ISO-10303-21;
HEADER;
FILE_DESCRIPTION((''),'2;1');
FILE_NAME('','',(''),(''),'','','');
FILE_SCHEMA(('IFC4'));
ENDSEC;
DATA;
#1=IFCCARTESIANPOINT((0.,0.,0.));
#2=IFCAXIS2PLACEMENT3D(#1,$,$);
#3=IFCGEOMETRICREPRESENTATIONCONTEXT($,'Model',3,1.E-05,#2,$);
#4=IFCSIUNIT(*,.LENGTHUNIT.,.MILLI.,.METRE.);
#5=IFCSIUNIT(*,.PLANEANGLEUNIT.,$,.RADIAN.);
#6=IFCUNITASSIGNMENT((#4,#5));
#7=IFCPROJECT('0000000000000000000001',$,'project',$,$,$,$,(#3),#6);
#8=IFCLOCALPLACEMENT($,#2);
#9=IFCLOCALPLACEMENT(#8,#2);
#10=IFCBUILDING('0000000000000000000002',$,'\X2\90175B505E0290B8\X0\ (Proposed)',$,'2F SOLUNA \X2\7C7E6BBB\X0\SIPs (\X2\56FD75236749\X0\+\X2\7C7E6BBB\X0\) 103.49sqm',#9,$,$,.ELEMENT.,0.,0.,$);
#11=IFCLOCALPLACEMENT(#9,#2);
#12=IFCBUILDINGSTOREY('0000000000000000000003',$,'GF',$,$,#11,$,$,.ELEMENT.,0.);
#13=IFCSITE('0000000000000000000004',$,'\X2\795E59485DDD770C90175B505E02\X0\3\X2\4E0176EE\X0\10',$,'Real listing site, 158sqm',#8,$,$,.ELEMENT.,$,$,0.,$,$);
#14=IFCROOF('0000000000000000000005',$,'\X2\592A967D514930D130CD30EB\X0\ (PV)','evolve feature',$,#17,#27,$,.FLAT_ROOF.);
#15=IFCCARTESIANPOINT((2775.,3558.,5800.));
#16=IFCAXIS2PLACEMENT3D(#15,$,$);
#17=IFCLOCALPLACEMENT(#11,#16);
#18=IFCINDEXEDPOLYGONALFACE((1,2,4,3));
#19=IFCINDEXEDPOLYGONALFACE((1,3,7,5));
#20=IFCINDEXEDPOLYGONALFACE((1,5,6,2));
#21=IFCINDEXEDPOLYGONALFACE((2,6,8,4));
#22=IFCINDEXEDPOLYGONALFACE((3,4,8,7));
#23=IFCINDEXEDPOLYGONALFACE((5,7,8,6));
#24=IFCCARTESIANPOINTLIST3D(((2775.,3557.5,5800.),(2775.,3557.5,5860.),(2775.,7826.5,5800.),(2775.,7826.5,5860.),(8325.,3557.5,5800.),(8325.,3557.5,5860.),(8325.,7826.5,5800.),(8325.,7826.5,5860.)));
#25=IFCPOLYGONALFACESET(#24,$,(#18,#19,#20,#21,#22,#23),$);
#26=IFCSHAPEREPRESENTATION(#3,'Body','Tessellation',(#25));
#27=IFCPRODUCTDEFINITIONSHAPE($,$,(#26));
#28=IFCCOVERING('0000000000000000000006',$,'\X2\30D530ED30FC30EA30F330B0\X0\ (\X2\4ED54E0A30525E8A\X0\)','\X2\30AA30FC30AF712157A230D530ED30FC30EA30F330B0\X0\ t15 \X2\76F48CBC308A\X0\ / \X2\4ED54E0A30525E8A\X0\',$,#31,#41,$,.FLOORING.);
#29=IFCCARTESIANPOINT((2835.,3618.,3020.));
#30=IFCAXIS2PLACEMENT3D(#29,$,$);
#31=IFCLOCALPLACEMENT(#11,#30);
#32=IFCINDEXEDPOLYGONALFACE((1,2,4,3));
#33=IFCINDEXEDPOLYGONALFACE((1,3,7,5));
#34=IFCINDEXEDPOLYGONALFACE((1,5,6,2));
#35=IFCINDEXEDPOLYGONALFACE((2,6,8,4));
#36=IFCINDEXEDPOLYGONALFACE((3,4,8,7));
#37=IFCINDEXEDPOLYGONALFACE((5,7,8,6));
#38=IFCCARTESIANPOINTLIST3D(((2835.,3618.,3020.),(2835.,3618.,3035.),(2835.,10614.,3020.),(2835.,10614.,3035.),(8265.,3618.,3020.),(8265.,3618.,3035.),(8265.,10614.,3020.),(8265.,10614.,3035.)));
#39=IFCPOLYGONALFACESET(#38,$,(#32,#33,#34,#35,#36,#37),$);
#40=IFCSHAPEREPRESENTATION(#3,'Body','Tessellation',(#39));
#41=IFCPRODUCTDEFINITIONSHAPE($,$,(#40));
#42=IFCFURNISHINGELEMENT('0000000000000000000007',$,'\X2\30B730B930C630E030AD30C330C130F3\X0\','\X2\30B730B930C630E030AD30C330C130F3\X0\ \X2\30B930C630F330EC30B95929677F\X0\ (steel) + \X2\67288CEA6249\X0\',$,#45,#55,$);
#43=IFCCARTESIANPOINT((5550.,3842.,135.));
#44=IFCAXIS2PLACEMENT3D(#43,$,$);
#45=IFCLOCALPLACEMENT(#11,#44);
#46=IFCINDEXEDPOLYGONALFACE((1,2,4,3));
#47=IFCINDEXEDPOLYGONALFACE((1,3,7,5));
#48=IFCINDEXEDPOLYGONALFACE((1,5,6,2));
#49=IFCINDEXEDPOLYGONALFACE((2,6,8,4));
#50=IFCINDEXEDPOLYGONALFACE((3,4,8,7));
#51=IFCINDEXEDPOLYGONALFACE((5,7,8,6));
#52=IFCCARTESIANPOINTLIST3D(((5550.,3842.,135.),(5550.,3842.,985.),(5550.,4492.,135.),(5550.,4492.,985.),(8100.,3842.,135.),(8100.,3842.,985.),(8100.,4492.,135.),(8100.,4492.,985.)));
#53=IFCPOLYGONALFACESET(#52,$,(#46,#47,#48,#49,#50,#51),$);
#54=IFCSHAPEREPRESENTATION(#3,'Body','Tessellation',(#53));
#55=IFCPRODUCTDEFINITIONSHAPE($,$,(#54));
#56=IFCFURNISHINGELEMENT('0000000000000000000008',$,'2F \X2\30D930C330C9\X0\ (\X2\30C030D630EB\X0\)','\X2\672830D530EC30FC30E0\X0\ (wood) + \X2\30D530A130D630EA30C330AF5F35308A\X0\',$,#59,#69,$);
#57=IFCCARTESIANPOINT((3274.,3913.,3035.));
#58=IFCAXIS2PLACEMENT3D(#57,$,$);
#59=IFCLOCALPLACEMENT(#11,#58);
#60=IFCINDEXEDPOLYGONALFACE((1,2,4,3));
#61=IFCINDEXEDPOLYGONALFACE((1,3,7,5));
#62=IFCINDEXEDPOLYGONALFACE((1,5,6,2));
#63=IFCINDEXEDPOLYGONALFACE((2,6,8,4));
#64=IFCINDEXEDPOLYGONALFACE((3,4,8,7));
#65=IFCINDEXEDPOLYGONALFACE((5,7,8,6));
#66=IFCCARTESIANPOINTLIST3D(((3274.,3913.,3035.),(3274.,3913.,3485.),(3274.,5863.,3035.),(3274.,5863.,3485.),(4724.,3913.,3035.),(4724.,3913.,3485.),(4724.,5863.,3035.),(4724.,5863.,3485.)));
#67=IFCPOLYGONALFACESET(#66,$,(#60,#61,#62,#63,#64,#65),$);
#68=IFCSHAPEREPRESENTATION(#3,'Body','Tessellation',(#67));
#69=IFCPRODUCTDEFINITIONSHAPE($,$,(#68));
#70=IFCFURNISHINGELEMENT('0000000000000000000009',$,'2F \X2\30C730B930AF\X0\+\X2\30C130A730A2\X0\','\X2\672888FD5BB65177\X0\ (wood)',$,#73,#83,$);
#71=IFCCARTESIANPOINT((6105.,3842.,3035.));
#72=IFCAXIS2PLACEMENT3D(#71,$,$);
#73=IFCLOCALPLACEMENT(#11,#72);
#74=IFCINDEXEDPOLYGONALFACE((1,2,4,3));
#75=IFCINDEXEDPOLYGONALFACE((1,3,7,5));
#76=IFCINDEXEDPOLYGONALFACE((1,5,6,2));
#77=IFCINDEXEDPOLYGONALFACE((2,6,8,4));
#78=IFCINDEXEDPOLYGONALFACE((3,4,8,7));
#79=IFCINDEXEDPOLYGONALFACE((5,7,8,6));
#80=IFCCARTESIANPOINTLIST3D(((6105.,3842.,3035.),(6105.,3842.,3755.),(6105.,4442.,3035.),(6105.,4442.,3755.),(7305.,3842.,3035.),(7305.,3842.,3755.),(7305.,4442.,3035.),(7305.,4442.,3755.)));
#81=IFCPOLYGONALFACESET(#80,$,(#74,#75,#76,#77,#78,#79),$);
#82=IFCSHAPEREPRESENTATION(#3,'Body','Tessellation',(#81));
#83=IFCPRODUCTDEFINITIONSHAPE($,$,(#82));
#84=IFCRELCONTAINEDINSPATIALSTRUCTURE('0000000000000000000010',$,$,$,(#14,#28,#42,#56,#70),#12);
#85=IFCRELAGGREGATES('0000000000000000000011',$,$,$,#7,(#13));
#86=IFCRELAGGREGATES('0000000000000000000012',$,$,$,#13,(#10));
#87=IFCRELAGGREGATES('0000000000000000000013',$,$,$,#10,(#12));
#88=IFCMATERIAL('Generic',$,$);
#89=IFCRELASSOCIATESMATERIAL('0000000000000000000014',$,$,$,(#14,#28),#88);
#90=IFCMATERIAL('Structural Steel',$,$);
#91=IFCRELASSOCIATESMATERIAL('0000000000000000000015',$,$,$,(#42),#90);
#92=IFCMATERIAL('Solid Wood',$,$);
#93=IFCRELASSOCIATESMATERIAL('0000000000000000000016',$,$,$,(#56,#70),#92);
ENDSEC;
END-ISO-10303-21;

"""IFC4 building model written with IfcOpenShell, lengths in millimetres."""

from ifc_helpers import new_model, si_unit, frame, frame_2d, origin, place, context, project, spatial, rectangle, extrude, material, element, save


model = new_model("IFC4")

# Units and contexts
model_context = context("Model", 3, precision=1e-05, world=origin())
ifc_project = project(units=[si_unit("LENGTHUNIT", "METRE", prefix="MILLI"), si_unit("PLANEANGLEUNIT", "RADIAN")], contexts=[model_context])

# Site, building, storey
site_placement = place(None, origin())
site = spatial("IfcSite", under=ifc_project, at=site_placement, Name="神奈川県逗子市3丁目10", ObjectType="Real listing site, 158sqm", CompositionType="ELEMENT", RefElevation=0.0)
building_placement = place(site_placement, origin())
building = spatial("IfcBuilding", under=site, at=building_placement, Name="逗子市邸 (Proposed)", ObjectType="2F SOLUNA 籾殻SIPs (国産杉+籾殻) 103.49sqm", CompositionType="ELEMENT", ElevationOfRefHeight=0.0, ElevationOfTerrain=0.0)
storey_placement = place(building_placement, origin())
storey = spatial("IfcBuildingStorey", under=building, at=storey_placement, Name="GF", CompositionType="ELEMENT", Elevation=0.0)

# Shared definitions
ifc_material_1 = material(Name="Solid Wood")

# Shared definitions
ifc_material_2 = material(Name="Generic")

# Roof
ifc_material_3 = material(Name="Structural Steel")
roof_1_placement = place(storey_placement, frame((2775.0, 3558.0, 5800.0)))
element("IfcRoof", 1, at=roof_1_placement, inside=storey, material=ifc_material_2, Name="太陽光パネル (PV)", Description="evolve feature", PredefinedType="FLAT_ROOF", context=model_context, shape_type="SweptSolid", body=[
    extrude(rectangle(XDim=5550.0, YDim=4269.0, at=frame_2d((2775.0, 2134.0))), frame((2775.0, 3558.0, 5800.0)), (0.0, 0.0, 1.0), 60.0),
])

# Covering
covering_placement = place(storey_placement, frame((2835.0, 3618.0, 3020.0)))
element("IfcCovering", 2, at=covering_placement, inside=storey, material=ifc_material_2, Name="フローリング (仕上げ床)", Description="オーク無垢フローリング t15 直貼り / 仕上げ床", PredefinedType="FLOORING", context=model_context, shape_type="SweptSolid", body=[
    extrude(rectangle(XDim=5430.0, YDim=6996.0, at=frame_2d((2715.0, 3498.0))), frame((2835.0, 3618.0, 3020.0)), (0.0, 0.0, 1.0), 15.0),
])

# Furnishing elements
furnishing_1_placement = place(storey_placement, frame((5550.0, 3842.0, 135.0)))
element("IfcFurnishingElement", 3, at=furnishing_1_placement, inside=storey, material=ifc_material_3, Name="システムキッチン", Description="システムキッチン ステンレス天板 (steel) + 木質扉", context=model_context, shape_type="SweptSolid", body=[
    extrude(rectangle(XDim=2550.0, YDim=650.0, at=frame_2d((1275.0, 325.0))), frame((5550.0, 3842.0, 135.0)), (0.0, 0.0, 1.0), 850.0),
])
furnishing_2_placement = place(storey_placement, frame((3274.0, 3913.0, 3035.0)))
element("IfcFurnishingElement", 4, at=furnishing_2_placement, inside=storey, material=ifc_material_1, Name="2F ベッド (ダブル)", Description="木フレーム (wood) + ファブリック張り", context=model_context, shape_type="SweptSolid", body=[
    extrude(rectangle(XDim=1450.0, YDim=1950.0, at=frame_2d((725.0, 975.0))), frame((3274.0, 3913.0, 3035.0)), (0.0, 0.0, 1.0), 450.0),
])
furnishing_3_placement = place(storey_placement, frame((6105.0, 3842.0, 3035.0)))
element("IfcFurnishingElement", 5, at=furnishing_3_placement, inside=storey, material=ifc_material_1, Name="2F デスク+チェア", Description="木製家具 (wood)", context=model_context, shape_type="SweptSolid", body=[
    extrude(rectangle(XDim=1200.0, YDim=600.0, at=frame_2d((600.0, 300.0))), frame((6105.0, 3842.0, 3035.0)), (0.0, 0.0, 1.0), 720.0),
])

save(model, "model.ifc")
